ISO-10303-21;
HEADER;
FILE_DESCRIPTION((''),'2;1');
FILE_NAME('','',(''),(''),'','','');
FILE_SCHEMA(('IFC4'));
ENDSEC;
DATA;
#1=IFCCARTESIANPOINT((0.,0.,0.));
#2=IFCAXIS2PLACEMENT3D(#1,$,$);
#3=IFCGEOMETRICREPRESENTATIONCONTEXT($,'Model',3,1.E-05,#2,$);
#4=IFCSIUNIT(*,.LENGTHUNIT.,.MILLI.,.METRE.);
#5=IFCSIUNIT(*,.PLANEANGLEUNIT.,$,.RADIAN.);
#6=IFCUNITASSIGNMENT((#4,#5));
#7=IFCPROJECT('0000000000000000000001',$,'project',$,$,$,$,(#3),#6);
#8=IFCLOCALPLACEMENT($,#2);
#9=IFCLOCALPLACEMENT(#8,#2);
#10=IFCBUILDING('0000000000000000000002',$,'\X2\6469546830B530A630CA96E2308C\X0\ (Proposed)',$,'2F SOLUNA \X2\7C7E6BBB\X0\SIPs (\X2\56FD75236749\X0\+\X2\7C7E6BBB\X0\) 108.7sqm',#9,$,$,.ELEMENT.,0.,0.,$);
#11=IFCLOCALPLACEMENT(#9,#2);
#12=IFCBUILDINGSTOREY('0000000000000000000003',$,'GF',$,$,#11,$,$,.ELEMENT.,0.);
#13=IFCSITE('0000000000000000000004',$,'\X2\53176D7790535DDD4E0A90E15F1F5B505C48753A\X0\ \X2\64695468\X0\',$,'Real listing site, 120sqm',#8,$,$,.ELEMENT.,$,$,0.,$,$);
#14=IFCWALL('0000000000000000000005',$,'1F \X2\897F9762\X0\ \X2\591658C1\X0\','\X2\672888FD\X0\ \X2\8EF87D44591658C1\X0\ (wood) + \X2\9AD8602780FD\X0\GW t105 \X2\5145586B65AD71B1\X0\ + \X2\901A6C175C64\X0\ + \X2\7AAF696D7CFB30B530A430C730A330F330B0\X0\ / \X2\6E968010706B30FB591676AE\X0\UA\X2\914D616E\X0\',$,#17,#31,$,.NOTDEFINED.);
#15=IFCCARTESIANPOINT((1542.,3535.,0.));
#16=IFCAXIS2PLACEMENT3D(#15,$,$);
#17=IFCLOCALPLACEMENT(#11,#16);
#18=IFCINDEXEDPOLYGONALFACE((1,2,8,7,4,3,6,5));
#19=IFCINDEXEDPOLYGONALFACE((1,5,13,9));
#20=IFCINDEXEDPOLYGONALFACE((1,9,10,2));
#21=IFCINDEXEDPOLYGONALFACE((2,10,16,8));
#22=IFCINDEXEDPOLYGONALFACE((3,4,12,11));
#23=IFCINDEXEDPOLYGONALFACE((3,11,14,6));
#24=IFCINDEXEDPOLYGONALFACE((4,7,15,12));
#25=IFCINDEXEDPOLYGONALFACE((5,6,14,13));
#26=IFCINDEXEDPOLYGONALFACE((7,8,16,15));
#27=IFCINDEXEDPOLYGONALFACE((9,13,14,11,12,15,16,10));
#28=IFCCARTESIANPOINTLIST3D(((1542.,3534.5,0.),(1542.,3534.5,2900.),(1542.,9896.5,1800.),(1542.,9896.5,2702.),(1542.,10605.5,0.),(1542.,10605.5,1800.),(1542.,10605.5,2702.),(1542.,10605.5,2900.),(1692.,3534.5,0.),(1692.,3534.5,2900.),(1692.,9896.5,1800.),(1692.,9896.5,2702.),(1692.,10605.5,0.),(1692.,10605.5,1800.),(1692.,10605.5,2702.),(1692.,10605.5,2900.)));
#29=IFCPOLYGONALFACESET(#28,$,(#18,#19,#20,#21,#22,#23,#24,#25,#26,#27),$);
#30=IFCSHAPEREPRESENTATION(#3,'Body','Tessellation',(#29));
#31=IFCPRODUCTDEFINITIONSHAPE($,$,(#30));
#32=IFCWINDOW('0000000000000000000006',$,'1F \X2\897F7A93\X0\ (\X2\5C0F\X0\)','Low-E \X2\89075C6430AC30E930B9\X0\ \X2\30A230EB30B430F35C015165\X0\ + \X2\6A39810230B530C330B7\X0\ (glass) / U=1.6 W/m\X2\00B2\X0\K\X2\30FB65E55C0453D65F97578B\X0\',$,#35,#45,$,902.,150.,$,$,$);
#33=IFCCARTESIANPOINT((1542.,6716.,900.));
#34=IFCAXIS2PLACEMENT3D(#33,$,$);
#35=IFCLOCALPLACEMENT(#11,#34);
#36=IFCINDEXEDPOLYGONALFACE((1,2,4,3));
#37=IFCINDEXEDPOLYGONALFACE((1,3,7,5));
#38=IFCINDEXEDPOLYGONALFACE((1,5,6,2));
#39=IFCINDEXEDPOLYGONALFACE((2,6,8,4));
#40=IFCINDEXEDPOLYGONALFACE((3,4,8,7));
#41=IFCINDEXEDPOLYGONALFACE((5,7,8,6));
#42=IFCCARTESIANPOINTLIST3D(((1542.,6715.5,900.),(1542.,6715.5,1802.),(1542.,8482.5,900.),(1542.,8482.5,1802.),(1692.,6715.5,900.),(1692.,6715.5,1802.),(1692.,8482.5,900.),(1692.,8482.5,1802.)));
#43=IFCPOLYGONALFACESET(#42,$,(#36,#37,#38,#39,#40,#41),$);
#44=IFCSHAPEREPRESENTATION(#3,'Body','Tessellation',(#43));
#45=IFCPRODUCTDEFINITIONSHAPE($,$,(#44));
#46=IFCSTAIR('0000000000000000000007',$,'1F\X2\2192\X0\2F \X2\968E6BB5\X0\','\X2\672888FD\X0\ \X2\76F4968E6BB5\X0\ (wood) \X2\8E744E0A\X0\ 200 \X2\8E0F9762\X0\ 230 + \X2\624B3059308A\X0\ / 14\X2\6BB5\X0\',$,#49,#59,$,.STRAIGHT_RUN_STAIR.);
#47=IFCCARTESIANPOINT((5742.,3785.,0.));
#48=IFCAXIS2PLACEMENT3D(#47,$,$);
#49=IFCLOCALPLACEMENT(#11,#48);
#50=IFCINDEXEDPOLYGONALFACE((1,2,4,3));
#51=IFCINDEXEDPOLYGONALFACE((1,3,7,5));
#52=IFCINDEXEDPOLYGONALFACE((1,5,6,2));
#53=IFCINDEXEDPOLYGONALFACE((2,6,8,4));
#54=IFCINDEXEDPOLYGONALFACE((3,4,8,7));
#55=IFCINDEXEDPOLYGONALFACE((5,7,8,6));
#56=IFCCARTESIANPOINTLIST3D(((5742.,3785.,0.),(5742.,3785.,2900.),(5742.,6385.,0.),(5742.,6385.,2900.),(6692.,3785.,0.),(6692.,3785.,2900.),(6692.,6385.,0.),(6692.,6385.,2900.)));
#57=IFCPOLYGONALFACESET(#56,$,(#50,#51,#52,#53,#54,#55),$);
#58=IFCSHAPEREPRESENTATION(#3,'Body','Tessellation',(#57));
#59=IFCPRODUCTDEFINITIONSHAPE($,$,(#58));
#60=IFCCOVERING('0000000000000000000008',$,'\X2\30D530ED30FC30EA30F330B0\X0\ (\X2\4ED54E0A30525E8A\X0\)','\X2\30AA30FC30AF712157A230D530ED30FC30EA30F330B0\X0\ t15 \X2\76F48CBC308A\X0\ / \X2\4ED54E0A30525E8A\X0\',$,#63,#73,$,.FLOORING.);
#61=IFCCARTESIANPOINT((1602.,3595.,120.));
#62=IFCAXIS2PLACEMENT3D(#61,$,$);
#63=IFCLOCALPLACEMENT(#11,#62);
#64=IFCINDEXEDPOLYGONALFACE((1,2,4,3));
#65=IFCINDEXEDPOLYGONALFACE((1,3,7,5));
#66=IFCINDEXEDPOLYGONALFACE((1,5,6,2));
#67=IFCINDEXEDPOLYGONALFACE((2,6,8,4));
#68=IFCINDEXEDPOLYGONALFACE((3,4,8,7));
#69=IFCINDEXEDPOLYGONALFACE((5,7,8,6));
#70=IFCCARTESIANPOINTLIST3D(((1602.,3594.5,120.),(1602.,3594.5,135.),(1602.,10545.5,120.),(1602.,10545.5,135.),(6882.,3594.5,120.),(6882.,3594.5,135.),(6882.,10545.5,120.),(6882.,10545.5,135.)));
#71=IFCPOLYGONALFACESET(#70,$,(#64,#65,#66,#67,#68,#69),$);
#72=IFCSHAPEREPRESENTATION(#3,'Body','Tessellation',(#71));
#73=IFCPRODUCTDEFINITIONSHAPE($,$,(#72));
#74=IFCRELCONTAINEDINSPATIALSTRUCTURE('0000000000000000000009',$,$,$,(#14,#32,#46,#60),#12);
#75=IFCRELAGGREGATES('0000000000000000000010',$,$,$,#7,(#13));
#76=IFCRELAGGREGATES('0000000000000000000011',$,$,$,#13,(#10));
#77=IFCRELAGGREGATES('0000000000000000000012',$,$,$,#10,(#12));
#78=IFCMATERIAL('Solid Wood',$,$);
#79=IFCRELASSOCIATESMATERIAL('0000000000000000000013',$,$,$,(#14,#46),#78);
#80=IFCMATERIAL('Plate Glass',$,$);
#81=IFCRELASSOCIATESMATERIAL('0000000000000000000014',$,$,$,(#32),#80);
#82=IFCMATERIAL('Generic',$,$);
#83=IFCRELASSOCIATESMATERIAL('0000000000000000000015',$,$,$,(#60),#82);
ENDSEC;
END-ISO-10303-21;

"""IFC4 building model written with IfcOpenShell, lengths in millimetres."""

from ifc_helpers import new_model, si_unit, frame, frame_2d, origin, place, context, project, spatial, rectangle, extrude, material, element, fill, save


model = new_model("IFC4")

# Units and contexts
model_context = context("Model", 3, precision=1e-05, world=origin())
ifc_project = project(units=[si_unit("LENGTHUNIT", "METRE", prefix="MILLI"), si_unit("PLANEANGLEUNIT", "RADIAN")], contexts=[model_context])

# Site, building, storey
site_placement = place(None, origin())
site = spatial("IfcSite", under=ifc_project, at=site_placement, Name="北海道川上郡弟子屈町 摩周", ObjectType="Real listing site, 120sqm", CompositionType="ELEMENT", RefElevation=0.0)
building_placement = place(site_placement, origin())
building = spatial("IfcBuilding", under=site, at=building_placement, Name="摩周サウナ離れ (Proposed)", ObjectType="2F SOLUNA 籾殻SIPs (国産杉+籾殻) 108.7sqm", CompositionType="ELEMENT", ElevationOfRefHeight=0.0, ElevationOfTerrain=0.0)
storey_placement = place(building_placement, origin())
storey = spatial("IfcBuildingStorey", under=building, at=storey_placement, Name="GF", CompositionType="ELEMENT", Elevation=0.0)

# Shared definitions
ifc_material_1 = material(Name="Solid Wood")
ifc_material_2 = material(Name="Generic")

# Shared definitions
ifc_material_3 = material(Name="Plate Glass")

# Wall, opening, window
wall_1_placement = place(storey_placement, frame((1542.0, 3535.0, 0.0)))
wall_1 = element("IfcWall", 1, at=wall_1_placement, inside=storey, material=ifc_material_1, Name="1F 西面 外壁", Description="木製 軸組外壁 (wood) + 高性能GW t105 充填断熱 + 通気層 + 窯業系サイディング / 準耐火・外皮UA配慮", PredefinedType="NOTDEFINED", context=model_context, shape_type="SweptSolid", body=[
    extrude(rectangle(XDim=150.0, YDim=7071.0, at=frame_2d((75.0, 3535.0))), frame((1542.0, 3535.0, 0.0)), (0.0, 0.0, 1.0), 2900.0),
])
opening_1_placement = place(storey_placement, frame((1542.0, 6716.0, 900.0)))
opening_1 = element("IfcOpeningElement", 2, at=opening_1_placement, cuts=wall_1, PredefinedType="NOTDEFINED", context=model_context, shape_type="SweptSolid", body=[
    extrude(rectangle(XDim=150.0, YDim=1767.0, at=frame_2d((75.0, 883.0))), frame((1542.0, 6716.0, 900.0)), (0.0, 0.0, 1.0), 902.0),
])
window_1_placement = place(storey_placement, frame((1542.0, 6716.0, 900.0)))
window_1 = element("IfcWindow", 3, at=window_1_placement, inside=storey, material=ifc_material_3, Name="1F 西窓 (小)", Description="Low-E 複層ガラス アルゴン封入 + 樹脂サッシ (glass) / U=1.6 W/m²K・日射取得型", OverallHeight=902.0, OverallWidth=150.0, context=model_context, shape_type="SweptSolid", body=[
    extrude(rectangle(XDim=150.0, YDim=1767.0, at=frame_2d((75.0, 883.0))), frame((1542.0, 6716.0, 900.0)), (0.0, 0.0, 1.0), 902.0),
])
fill(opening_1, window_1)

# Stair
stair_placement = place(storey_placement, frame((5742.0, 3785.0, 0.0)))
element("IfcStair", 4, at=stair_placement, inside=storey, material=ifc_material_1, Name="1F→2F 階段", Description="木製 直階段 (wood) 蹴上 200 踏面 230 + 手すり / 14段", PredefinedType="STRAIGHT_RUN_STAIR", context=model_context, shape_type="SweptSolid", body=[
    extrude(rectangle(XDim=950.0, YDim=2600.0, at=frame_2d((475.0, 1300.0))), frame((5742.0, 3785.0, 0.0)), (0.0, 0.0, 1.0), 2900.0),
])

# Covering
covering_placement = place(storey_placement, frame((1602.0, 3595.0, 120.0)))
element("IfcCovering", 5, at=covering_placement, inside=storey, material=ifc_material_2, Name="フローリング (仕上げ床)", Description="オーク無垢フローリング t15 直貼り / 仕上げ床", PredefinedType="FLOORING", context=model_context, shape_type="SweptSolid", body=[
    extrude(rectangle(XDim=5280.0, YDim=6951.0, at=frame_2d((2640.0, 3475.0))), frame((1602.0, 3595.0, 120.0)), (0.0, 0.0, 1.0), 15.0),
])

save(model, "model.ifc")
